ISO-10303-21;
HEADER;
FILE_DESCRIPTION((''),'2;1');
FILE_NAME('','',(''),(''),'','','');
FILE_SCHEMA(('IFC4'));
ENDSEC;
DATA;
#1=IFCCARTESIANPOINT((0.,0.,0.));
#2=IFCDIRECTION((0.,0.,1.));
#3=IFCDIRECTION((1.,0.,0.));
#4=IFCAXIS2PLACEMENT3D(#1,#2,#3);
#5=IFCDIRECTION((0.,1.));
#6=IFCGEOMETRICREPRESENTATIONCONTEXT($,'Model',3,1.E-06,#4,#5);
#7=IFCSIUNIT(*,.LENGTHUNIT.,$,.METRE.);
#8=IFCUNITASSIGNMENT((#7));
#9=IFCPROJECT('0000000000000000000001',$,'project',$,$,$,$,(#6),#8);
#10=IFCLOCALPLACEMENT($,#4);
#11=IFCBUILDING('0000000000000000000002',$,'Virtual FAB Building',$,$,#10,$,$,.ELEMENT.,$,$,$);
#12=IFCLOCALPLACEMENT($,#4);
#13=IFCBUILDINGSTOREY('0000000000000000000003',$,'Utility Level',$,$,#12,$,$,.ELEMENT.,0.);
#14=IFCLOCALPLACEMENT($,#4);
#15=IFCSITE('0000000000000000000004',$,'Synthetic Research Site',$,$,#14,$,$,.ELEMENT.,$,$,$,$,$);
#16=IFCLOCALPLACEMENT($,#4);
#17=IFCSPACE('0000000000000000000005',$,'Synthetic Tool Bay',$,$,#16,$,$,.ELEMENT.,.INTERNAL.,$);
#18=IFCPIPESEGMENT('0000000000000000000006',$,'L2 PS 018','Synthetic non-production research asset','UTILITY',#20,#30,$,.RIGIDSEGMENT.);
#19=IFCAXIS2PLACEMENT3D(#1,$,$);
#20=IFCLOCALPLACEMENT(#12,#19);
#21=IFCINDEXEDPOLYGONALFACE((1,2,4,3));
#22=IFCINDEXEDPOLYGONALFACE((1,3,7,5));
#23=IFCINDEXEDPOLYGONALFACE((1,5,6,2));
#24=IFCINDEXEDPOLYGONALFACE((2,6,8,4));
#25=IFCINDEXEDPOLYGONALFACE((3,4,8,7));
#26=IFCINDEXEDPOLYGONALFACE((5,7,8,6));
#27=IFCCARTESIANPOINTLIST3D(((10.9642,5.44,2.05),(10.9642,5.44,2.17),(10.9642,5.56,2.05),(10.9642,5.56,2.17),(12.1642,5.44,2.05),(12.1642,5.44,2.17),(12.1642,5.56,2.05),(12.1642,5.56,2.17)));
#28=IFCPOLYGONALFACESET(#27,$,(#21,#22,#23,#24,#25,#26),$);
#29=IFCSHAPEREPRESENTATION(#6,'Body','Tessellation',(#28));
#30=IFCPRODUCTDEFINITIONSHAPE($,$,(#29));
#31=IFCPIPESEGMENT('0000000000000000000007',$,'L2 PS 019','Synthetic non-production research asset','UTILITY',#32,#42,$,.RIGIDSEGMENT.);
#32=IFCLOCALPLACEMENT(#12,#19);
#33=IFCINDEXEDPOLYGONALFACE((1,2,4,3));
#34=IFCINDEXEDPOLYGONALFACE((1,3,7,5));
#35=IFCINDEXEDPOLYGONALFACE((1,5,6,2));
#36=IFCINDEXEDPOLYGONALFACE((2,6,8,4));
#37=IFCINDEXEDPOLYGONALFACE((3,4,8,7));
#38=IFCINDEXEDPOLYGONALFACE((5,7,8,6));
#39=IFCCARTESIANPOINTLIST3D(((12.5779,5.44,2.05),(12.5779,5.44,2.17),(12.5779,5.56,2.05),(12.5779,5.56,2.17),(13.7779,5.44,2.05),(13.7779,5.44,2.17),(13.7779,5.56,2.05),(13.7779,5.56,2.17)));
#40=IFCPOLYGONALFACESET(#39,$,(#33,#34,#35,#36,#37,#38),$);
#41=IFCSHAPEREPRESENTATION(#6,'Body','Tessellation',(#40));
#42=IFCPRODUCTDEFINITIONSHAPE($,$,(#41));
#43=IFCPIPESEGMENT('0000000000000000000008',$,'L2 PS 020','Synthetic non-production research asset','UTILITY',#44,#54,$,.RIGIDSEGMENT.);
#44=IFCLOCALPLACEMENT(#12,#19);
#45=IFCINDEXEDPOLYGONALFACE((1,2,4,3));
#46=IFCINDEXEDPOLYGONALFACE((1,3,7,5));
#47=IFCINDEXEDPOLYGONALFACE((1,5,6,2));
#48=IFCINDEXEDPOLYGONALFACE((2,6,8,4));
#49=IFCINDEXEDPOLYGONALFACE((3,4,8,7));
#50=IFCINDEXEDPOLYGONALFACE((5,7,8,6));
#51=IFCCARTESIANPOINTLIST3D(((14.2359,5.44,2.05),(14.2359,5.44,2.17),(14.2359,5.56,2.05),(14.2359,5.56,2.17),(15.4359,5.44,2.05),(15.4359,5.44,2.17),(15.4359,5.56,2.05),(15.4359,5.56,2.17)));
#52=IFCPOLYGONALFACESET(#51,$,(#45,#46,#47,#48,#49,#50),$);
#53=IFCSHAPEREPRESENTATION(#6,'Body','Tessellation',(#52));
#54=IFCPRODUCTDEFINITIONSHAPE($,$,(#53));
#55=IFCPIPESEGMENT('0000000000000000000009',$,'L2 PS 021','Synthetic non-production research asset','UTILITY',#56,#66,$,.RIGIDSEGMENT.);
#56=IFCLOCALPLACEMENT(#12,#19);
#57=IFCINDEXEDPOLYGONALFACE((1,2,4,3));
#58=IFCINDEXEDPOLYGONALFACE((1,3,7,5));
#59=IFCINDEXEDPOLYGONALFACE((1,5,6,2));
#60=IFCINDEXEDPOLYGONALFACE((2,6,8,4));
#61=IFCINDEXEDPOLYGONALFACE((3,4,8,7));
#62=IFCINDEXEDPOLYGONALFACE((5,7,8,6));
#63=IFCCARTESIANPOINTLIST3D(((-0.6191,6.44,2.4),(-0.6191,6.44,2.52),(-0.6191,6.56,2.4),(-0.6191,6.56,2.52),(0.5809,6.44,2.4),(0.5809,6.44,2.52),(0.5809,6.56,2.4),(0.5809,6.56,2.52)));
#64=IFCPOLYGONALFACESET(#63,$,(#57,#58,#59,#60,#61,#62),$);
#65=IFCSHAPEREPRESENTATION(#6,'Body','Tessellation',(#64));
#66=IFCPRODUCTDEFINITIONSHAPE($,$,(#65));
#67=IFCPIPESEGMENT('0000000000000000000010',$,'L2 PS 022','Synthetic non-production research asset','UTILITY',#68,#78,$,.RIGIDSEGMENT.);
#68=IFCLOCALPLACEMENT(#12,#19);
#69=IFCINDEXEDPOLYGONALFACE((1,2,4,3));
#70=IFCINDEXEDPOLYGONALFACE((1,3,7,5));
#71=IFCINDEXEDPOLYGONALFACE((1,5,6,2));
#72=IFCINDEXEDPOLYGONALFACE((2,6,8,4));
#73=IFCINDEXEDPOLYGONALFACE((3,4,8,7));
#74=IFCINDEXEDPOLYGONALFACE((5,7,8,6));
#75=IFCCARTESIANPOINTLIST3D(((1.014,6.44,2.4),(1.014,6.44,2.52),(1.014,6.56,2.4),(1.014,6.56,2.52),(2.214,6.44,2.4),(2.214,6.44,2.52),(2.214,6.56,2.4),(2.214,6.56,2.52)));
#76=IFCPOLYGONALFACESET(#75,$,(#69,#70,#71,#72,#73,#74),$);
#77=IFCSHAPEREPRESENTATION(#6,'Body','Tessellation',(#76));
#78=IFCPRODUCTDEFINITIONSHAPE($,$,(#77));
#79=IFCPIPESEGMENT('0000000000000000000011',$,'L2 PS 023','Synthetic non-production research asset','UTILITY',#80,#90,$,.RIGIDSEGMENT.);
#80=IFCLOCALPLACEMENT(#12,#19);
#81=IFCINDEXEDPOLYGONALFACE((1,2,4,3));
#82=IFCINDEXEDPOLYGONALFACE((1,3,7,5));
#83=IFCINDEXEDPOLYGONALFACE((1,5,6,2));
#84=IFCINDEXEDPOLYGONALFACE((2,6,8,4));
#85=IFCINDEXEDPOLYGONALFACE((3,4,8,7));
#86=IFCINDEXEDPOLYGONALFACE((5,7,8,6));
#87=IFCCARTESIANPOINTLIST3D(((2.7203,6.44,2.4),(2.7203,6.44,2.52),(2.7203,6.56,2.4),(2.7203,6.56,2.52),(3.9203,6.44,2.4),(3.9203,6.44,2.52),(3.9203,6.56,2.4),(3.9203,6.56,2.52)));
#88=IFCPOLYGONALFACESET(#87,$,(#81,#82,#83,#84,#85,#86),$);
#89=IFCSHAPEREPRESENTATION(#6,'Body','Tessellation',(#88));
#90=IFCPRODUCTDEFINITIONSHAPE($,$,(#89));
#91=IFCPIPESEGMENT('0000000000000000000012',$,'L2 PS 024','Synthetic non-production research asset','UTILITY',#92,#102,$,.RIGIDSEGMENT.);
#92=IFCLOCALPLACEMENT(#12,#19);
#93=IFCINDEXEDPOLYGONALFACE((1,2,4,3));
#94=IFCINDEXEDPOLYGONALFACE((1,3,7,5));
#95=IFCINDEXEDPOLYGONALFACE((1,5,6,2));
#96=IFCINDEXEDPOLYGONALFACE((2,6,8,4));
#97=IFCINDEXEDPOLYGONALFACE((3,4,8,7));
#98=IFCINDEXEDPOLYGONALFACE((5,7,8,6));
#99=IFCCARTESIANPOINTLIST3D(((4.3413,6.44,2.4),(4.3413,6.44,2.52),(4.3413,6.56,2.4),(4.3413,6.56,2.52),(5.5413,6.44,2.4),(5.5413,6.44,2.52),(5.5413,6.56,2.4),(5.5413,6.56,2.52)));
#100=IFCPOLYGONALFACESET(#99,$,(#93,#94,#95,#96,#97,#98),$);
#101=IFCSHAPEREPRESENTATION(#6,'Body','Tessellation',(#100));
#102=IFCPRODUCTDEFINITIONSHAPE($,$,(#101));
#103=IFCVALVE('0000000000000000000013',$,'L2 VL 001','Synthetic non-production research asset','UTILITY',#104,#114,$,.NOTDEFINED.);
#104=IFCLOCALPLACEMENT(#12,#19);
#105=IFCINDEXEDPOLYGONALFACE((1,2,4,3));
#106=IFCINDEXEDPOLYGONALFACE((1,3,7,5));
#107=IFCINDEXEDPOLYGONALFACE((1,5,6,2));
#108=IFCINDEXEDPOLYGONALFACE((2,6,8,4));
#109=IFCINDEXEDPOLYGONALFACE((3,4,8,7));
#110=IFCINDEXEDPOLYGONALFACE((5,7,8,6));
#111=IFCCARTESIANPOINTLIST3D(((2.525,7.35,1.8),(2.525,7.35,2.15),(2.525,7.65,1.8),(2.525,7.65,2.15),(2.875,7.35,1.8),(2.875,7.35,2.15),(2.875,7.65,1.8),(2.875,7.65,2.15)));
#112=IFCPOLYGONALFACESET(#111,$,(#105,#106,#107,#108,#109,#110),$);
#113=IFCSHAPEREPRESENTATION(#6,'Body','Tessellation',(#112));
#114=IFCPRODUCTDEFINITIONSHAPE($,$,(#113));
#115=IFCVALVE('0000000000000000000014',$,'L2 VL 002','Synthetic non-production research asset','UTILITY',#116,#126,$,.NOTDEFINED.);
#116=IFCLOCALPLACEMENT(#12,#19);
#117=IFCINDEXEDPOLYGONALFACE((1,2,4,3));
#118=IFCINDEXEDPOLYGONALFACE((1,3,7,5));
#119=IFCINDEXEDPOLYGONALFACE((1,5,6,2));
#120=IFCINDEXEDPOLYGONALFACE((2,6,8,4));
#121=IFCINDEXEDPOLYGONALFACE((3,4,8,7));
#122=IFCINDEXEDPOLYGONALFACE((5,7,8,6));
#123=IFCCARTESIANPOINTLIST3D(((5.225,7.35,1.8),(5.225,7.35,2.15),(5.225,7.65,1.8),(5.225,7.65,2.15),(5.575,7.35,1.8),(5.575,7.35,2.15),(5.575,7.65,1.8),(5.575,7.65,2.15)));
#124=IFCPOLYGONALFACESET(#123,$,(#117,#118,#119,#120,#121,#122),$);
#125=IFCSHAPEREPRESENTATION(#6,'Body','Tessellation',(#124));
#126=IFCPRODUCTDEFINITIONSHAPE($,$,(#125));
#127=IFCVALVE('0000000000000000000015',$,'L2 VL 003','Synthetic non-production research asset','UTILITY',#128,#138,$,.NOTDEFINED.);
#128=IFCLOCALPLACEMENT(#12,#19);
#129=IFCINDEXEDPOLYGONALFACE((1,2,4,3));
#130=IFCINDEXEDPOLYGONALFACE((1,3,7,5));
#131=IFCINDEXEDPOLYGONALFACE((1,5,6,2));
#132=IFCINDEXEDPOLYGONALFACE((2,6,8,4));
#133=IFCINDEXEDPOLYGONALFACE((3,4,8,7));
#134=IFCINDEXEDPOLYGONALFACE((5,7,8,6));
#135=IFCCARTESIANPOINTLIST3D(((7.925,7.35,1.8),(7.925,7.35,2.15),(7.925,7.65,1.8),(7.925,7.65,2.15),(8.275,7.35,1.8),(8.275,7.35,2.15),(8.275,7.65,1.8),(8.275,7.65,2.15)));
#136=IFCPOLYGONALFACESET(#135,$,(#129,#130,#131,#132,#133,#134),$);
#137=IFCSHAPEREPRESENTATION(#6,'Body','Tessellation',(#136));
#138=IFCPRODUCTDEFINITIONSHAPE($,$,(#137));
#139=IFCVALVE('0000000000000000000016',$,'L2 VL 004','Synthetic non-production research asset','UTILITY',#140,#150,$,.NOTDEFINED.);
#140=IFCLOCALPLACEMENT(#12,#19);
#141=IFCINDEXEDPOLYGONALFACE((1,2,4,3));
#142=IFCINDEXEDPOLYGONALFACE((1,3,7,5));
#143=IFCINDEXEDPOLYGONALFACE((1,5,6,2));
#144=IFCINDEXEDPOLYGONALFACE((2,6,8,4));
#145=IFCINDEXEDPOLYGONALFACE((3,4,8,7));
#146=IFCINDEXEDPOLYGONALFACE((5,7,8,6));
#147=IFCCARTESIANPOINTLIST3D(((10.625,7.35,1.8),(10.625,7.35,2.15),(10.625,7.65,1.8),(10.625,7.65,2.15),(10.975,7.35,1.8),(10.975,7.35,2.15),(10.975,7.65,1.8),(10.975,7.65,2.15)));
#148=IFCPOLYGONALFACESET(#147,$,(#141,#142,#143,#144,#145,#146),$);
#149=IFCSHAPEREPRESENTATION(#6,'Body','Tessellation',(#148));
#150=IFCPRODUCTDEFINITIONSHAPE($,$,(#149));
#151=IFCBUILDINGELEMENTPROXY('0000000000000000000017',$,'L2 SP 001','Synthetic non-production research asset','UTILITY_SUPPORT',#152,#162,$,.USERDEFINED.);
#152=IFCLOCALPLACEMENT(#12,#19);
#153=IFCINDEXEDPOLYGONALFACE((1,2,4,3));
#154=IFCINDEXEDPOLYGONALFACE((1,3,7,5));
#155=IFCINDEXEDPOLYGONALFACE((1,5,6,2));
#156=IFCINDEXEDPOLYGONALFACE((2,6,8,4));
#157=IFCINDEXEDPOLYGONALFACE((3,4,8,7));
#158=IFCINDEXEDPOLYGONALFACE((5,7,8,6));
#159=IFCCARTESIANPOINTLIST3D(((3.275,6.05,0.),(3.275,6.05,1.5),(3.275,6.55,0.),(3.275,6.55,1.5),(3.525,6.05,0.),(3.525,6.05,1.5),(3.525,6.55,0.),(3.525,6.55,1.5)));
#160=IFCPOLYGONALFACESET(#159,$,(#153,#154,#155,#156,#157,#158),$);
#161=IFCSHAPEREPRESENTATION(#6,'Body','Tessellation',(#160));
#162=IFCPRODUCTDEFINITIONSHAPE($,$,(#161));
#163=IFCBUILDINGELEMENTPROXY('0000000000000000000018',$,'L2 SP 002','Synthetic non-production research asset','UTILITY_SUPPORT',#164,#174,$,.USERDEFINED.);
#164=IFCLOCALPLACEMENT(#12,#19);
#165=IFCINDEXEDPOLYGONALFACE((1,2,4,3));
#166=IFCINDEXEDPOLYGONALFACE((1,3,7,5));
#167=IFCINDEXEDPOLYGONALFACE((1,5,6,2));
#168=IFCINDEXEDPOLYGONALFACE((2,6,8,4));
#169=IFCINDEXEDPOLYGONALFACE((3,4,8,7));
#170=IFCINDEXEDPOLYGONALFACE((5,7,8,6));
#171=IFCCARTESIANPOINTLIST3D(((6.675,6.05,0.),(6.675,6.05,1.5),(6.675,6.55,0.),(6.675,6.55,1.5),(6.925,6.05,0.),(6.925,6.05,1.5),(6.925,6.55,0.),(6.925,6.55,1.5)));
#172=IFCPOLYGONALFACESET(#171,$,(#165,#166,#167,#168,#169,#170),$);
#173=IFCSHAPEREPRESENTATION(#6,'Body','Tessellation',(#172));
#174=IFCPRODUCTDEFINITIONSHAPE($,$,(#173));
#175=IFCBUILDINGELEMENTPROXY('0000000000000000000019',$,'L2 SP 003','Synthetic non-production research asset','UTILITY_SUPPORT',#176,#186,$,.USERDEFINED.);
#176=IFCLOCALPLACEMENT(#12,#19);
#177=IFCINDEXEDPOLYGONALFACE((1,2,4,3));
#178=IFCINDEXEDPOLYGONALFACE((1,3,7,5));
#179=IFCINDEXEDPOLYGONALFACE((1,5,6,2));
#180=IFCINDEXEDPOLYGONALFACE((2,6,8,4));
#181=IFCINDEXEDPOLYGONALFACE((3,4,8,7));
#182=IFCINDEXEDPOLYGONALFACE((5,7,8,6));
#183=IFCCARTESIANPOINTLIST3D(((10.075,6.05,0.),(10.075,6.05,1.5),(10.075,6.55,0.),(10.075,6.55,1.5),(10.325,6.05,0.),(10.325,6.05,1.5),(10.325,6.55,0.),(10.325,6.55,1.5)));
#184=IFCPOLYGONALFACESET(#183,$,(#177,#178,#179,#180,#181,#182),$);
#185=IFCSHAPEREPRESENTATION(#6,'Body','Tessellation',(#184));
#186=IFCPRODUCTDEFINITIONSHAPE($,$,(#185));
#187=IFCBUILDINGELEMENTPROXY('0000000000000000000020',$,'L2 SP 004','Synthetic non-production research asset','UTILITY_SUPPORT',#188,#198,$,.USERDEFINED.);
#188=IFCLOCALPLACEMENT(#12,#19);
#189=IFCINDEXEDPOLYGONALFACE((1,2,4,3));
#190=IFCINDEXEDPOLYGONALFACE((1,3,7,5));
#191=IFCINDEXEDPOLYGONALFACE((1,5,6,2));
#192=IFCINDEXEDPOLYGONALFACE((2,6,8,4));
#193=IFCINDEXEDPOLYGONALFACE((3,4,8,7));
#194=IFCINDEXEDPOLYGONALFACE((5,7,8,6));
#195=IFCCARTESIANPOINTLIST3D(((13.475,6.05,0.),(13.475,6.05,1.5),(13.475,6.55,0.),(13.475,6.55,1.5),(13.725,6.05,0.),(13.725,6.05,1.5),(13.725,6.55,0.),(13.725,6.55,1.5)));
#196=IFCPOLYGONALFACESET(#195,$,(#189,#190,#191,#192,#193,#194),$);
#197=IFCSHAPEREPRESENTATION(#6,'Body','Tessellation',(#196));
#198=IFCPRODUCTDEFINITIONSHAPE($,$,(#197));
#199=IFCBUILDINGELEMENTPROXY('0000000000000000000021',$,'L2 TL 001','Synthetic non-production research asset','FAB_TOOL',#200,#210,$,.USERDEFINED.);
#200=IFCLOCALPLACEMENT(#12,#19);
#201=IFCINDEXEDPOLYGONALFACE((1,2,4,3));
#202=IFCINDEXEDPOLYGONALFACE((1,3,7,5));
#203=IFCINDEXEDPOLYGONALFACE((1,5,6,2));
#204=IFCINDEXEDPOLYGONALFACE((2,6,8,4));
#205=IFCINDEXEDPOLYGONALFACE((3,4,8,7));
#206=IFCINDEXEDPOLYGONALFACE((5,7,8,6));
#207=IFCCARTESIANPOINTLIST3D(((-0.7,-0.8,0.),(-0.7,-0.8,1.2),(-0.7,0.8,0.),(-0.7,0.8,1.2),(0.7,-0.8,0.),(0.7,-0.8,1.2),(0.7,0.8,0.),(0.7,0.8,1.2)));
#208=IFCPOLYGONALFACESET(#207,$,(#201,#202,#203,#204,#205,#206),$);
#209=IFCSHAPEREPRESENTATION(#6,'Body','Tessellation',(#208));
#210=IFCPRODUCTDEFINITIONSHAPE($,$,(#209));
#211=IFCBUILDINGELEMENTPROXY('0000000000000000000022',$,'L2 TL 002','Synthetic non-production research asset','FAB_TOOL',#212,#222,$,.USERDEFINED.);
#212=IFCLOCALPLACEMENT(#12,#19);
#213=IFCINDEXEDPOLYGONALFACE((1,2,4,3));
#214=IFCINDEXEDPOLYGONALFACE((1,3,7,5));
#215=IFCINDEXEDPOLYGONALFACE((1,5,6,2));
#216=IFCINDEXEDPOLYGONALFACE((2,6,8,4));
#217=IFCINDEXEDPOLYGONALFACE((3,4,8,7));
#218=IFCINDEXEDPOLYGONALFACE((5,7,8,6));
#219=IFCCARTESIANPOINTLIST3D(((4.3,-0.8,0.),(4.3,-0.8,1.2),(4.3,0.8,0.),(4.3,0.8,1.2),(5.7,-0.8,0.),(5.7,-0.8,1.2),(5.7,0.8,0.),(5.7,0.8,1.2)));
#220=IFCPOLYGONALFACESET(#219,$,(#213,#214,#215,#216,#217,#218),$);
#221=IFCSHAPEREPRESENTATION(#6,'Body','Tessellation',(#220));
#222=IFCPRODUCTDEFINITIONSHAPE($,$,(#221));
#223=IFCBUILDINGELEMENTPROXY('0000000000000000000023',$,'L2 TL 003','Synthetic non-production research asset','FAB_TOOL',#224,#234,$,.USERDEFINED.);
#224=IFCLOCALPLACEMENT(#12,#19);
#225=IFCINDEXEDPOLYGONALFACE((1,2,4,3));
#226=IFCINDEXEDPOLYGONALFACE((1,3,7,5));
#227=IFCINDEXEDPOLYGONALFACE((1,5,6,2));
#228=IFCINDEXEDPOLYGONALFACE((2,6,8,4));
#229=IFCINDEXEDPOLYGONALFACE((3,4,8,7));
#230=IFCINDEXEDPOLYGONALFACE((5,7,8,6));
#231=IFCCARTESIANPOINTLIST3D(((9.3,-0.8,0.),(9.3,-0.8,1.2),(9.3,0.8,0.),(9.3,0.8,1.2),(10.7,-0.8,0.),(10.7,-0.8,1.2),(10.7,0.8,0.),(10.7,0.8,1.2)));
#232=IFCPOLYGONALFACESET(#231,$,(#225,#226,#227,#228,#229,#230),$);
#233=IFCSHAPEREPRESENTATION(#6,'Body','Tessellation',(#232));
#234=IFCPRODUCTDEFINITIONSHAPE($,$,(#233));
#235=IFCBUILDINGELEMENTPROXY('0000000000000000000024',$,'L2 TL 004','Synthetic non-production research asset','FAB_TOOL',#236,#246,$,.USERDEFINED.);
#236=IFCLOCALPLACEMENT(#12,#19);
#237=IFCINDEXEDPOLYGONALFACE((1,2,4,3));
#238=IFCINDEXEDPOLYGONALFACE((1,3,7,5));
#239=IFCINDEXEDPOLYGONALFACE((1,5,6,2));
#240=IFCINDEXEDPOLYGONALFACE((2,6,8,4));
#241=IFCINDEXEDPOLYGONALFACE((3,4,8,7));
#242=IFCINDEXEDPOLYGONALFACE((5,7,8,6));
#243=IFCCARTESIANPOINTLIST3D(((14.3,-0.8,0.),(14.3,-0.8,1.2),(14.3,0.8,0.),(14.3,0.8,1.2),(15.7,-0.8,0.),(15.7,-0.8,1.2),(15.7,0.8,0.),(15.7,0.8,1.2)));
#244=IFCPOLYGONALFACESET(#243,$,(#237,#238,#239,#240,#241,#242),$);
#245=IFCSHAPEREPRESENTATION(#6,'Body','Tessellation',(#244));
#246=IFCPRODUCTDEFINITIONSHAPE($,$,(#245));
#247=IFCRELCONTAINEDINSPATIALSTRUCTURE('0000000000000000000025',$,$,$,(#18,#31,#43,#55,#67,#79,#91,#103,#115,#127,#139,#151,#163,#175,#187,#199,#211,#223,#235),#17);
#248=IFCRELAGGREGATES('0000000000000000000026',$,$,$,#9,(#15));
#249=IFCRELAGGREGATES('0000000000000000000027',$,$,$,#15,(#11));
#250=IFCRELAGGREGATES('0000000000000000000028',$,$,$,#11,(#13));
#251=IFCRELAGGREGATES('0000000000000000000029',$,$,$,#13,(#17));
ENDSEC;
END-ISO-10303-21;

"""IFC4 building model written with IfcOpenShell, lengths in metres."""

from ifc_helpers import new_model, si_unit, direction, frame, origin_with_axes, origin_2d_with_axis, place, context, project, spatial, rectangle, extrude, element, save


model = new_model("IFC4")

# Units and contexts
model_context = context("Model", 3, precision=1e-06, world=origin_with_axes(), true_north=direction((0.0, 1.0)))
ifc_project = project(units=[si_unit("LENGTHUNIT", "METRE")], contexts=[model_context])

# Site, building, storey, space
site_placement = place(None, origin_with_axes())
site = spatial("IfcSite", under=ifc_project, at=site_placement, Name="Synthetic Research Site", CompositionType="ELEMENT")
building_placement = place(None, origin_with_axes())
building = spatial("IfcBuilding", under=site, at=building_placement, Name="Virtual FAB Building", CompositionType="ELEMENT")
storey_placement = place(None, origin_with_axes())
storey = spatial("IfcBuildingStorey", under=building, at=storey_placement, Name="Utility Level", CompositionType="ELEMENT", Elevation=0.0)
space_placement = place(None, origin_with_axes())
space = spatial("IfcSpace", under=storey, at=space_placement, Name="Synthetic Tool Bay", CompositionType="ELEMENT", PredefinedType="INTERNAL")

# Pipe segments
for number, where, z_axis, x_axis, name in (
    (1, (11.5642, 5.5, 2.05), (0.0, 0.0, 1.0), (1.0, 0.0, 0.0), "L2 PS 018"),
    (2, (13.1779, 5.5, 2.05), (0.0, 0.0, 1.0), (1.0, 0.0, 0.0), "L2 PS 019"),
    (3, (14.8359, 5.5, 2.05), (0.0, 0.0, 1.0), (1.0, 0.0, 0.0), "L2 PS 020"),
    (4, (-0.0191, 6.5, 2.4), (0.0, 0.0, 1.0), (1.0, 0.0, 0.0), "L2 PS 021"),
    (5, (1.614, 6.5, 2.4), (0.0, 0.0, 1.0), (1.0, 0.0, 0.0), "L2 PS 022"),
    (6, (3.3203, 6.5, 2.4), (0.0, 0.0, 1.0), (1.0, 0.0, 0.0), "L2 PS 023"),
    (7, (4.9413, 6.5, 2.4), (0.0, 0.0, 1.0), (1.0, 0.0, 0.0), "L2 PS 024"),
):
    element("IfcPipeSegment", number, at=place(None, frame(where, z_axis=z_axis, x_axis=x_axis)), inside=space, Name=name, Description="Synthetic non-production research asset", ObjectType="UTILITY", PredefinedType="RIGIDSEGMENT", context=model_context, shape_type="SweptSolid", body=[
        extrude(rectangle(XDim=1.2, YDim=0.12, at=origin_2d_with_axis()), origin_with_axes(), (0.0, 0.0, 1.0), 0.12),
    ])

# Valves
for number, where, z_axis, x_axis, name in (
    (8, (2.7, 7.5, 1.8), (0.0, 0.0, 1.0), (1.0, 0.0, 0.0), "L2 VL 001"),
    (9, (5.4, 7.5, 1.8), (0.0, 0.0, 1.0), (1.0, 0.0, 0.0), "L2 VL 002"),
    (10, (8.1, 7.5, 1.8), (0.0, 0.0, 1.0), (1.0, 0.0, 0.0), "L2 VL 003"),
    (11, (10.8, 7.5, 1.8), (0.0, 0.0, 1.0), (1.0, 0.0, 0.0), "L2 VL 004"),
):
    element("IfcValve", number, at=place(None, frame(where, z_axis=z_axis, x_axis=x_axis)), inside=space, Name=name, Description="Synthetic non-production research asset", ObjectType="UTILITY", PredefinedType="NOTDEFINED", context=model_context, shape_type="SweptSolid", body=[
        extrude(rectangle(XDim=0.35, YDim=0.3, at=origin_2d_with_axis()), origin_with_axes(), (0.0, 0.0, 1.0), 0.35),
    ])

# Building element proxies
for number, where, z_axis, x_axis, name in (
    (12, (3.4, 6.3, 0.0), (0.0, 0.0, 1.0), (1.0, 0.0, 0.0), "L2 SP 001"),
    (13, (6.8, 6.3, 0.0), (0.0, 0.0, 1.0), (1.0, 0.0, 0.0), "L2 SP 002"),
    (14, (10.2, 6.3, 0.0), (0.0, 0.0, 1.0), (1.0, 0.0, 0.0), "L2 SP 003"),
    (15, (13.6, 6.3, 0.0), (0.0, 0.0, 1.0), (1.0, 0.0, 0.0), "L2 SP 004"),
):
    element("IfcBuildingElementProxy", number, at=place(None, frame(where, z_axis=z_axis, x_axis=x_axis)), inside=space, Name=name, Description="Synthetic non-production research asset", ObjectType="UTILITY_SUPPORT", PredefinedType="USERDEFINED", context=model_context, shape_type="SweptSolid", body=[
        extrude(rectangle(XDim=0.25, YDim=0.5, at=origin_2d_with_axis()), origin_with_axes(), (0.0, 0.0, 1.0), 1.5),
    ])
for number, where, z_axis, x_axis, name in (
    (16, (0.0, 0.0, 0.0), (0.0, 0.0, 1.0), (1.0, 0.0, 0.0), "L2 TL 001"),
    (17, (5.0, 0.0, 0.0), (0.0, 0.0, 1.0), (1.0, 0.0, 0.0), "L2 TL 002"),
    (18, (10.0, 0.0, 0.0), (0.0, 0.0, 1.0), (1.0, 0.0, 0.0), "L2 TL 003"),
    (19, (15.0, 0.0, 0.0), (0.0, 0.0, 1.0), (1.0, 0.0, 0.0), "L2 TL 004"),
):
    element("IfcBuildingElementProxy", number, at=place(None, frame(where, z_axis=z_axis, x_axis=x_axis)), inside=space, Name=name, Description="Synthetic non-production research asset", ObjectType="FAB_TOOL", PredefinedType="USERDEFINED", context=model_context, shape_type="SweptSolid", body=[
        extrude(rectangle(XDim=1.4, YDim=1.6, at=origin_2d_with_axis()), origin_with_axes(), (0.0, 0.0, 1.0), 1.2),
    ])

save(model, "model.ifc")
